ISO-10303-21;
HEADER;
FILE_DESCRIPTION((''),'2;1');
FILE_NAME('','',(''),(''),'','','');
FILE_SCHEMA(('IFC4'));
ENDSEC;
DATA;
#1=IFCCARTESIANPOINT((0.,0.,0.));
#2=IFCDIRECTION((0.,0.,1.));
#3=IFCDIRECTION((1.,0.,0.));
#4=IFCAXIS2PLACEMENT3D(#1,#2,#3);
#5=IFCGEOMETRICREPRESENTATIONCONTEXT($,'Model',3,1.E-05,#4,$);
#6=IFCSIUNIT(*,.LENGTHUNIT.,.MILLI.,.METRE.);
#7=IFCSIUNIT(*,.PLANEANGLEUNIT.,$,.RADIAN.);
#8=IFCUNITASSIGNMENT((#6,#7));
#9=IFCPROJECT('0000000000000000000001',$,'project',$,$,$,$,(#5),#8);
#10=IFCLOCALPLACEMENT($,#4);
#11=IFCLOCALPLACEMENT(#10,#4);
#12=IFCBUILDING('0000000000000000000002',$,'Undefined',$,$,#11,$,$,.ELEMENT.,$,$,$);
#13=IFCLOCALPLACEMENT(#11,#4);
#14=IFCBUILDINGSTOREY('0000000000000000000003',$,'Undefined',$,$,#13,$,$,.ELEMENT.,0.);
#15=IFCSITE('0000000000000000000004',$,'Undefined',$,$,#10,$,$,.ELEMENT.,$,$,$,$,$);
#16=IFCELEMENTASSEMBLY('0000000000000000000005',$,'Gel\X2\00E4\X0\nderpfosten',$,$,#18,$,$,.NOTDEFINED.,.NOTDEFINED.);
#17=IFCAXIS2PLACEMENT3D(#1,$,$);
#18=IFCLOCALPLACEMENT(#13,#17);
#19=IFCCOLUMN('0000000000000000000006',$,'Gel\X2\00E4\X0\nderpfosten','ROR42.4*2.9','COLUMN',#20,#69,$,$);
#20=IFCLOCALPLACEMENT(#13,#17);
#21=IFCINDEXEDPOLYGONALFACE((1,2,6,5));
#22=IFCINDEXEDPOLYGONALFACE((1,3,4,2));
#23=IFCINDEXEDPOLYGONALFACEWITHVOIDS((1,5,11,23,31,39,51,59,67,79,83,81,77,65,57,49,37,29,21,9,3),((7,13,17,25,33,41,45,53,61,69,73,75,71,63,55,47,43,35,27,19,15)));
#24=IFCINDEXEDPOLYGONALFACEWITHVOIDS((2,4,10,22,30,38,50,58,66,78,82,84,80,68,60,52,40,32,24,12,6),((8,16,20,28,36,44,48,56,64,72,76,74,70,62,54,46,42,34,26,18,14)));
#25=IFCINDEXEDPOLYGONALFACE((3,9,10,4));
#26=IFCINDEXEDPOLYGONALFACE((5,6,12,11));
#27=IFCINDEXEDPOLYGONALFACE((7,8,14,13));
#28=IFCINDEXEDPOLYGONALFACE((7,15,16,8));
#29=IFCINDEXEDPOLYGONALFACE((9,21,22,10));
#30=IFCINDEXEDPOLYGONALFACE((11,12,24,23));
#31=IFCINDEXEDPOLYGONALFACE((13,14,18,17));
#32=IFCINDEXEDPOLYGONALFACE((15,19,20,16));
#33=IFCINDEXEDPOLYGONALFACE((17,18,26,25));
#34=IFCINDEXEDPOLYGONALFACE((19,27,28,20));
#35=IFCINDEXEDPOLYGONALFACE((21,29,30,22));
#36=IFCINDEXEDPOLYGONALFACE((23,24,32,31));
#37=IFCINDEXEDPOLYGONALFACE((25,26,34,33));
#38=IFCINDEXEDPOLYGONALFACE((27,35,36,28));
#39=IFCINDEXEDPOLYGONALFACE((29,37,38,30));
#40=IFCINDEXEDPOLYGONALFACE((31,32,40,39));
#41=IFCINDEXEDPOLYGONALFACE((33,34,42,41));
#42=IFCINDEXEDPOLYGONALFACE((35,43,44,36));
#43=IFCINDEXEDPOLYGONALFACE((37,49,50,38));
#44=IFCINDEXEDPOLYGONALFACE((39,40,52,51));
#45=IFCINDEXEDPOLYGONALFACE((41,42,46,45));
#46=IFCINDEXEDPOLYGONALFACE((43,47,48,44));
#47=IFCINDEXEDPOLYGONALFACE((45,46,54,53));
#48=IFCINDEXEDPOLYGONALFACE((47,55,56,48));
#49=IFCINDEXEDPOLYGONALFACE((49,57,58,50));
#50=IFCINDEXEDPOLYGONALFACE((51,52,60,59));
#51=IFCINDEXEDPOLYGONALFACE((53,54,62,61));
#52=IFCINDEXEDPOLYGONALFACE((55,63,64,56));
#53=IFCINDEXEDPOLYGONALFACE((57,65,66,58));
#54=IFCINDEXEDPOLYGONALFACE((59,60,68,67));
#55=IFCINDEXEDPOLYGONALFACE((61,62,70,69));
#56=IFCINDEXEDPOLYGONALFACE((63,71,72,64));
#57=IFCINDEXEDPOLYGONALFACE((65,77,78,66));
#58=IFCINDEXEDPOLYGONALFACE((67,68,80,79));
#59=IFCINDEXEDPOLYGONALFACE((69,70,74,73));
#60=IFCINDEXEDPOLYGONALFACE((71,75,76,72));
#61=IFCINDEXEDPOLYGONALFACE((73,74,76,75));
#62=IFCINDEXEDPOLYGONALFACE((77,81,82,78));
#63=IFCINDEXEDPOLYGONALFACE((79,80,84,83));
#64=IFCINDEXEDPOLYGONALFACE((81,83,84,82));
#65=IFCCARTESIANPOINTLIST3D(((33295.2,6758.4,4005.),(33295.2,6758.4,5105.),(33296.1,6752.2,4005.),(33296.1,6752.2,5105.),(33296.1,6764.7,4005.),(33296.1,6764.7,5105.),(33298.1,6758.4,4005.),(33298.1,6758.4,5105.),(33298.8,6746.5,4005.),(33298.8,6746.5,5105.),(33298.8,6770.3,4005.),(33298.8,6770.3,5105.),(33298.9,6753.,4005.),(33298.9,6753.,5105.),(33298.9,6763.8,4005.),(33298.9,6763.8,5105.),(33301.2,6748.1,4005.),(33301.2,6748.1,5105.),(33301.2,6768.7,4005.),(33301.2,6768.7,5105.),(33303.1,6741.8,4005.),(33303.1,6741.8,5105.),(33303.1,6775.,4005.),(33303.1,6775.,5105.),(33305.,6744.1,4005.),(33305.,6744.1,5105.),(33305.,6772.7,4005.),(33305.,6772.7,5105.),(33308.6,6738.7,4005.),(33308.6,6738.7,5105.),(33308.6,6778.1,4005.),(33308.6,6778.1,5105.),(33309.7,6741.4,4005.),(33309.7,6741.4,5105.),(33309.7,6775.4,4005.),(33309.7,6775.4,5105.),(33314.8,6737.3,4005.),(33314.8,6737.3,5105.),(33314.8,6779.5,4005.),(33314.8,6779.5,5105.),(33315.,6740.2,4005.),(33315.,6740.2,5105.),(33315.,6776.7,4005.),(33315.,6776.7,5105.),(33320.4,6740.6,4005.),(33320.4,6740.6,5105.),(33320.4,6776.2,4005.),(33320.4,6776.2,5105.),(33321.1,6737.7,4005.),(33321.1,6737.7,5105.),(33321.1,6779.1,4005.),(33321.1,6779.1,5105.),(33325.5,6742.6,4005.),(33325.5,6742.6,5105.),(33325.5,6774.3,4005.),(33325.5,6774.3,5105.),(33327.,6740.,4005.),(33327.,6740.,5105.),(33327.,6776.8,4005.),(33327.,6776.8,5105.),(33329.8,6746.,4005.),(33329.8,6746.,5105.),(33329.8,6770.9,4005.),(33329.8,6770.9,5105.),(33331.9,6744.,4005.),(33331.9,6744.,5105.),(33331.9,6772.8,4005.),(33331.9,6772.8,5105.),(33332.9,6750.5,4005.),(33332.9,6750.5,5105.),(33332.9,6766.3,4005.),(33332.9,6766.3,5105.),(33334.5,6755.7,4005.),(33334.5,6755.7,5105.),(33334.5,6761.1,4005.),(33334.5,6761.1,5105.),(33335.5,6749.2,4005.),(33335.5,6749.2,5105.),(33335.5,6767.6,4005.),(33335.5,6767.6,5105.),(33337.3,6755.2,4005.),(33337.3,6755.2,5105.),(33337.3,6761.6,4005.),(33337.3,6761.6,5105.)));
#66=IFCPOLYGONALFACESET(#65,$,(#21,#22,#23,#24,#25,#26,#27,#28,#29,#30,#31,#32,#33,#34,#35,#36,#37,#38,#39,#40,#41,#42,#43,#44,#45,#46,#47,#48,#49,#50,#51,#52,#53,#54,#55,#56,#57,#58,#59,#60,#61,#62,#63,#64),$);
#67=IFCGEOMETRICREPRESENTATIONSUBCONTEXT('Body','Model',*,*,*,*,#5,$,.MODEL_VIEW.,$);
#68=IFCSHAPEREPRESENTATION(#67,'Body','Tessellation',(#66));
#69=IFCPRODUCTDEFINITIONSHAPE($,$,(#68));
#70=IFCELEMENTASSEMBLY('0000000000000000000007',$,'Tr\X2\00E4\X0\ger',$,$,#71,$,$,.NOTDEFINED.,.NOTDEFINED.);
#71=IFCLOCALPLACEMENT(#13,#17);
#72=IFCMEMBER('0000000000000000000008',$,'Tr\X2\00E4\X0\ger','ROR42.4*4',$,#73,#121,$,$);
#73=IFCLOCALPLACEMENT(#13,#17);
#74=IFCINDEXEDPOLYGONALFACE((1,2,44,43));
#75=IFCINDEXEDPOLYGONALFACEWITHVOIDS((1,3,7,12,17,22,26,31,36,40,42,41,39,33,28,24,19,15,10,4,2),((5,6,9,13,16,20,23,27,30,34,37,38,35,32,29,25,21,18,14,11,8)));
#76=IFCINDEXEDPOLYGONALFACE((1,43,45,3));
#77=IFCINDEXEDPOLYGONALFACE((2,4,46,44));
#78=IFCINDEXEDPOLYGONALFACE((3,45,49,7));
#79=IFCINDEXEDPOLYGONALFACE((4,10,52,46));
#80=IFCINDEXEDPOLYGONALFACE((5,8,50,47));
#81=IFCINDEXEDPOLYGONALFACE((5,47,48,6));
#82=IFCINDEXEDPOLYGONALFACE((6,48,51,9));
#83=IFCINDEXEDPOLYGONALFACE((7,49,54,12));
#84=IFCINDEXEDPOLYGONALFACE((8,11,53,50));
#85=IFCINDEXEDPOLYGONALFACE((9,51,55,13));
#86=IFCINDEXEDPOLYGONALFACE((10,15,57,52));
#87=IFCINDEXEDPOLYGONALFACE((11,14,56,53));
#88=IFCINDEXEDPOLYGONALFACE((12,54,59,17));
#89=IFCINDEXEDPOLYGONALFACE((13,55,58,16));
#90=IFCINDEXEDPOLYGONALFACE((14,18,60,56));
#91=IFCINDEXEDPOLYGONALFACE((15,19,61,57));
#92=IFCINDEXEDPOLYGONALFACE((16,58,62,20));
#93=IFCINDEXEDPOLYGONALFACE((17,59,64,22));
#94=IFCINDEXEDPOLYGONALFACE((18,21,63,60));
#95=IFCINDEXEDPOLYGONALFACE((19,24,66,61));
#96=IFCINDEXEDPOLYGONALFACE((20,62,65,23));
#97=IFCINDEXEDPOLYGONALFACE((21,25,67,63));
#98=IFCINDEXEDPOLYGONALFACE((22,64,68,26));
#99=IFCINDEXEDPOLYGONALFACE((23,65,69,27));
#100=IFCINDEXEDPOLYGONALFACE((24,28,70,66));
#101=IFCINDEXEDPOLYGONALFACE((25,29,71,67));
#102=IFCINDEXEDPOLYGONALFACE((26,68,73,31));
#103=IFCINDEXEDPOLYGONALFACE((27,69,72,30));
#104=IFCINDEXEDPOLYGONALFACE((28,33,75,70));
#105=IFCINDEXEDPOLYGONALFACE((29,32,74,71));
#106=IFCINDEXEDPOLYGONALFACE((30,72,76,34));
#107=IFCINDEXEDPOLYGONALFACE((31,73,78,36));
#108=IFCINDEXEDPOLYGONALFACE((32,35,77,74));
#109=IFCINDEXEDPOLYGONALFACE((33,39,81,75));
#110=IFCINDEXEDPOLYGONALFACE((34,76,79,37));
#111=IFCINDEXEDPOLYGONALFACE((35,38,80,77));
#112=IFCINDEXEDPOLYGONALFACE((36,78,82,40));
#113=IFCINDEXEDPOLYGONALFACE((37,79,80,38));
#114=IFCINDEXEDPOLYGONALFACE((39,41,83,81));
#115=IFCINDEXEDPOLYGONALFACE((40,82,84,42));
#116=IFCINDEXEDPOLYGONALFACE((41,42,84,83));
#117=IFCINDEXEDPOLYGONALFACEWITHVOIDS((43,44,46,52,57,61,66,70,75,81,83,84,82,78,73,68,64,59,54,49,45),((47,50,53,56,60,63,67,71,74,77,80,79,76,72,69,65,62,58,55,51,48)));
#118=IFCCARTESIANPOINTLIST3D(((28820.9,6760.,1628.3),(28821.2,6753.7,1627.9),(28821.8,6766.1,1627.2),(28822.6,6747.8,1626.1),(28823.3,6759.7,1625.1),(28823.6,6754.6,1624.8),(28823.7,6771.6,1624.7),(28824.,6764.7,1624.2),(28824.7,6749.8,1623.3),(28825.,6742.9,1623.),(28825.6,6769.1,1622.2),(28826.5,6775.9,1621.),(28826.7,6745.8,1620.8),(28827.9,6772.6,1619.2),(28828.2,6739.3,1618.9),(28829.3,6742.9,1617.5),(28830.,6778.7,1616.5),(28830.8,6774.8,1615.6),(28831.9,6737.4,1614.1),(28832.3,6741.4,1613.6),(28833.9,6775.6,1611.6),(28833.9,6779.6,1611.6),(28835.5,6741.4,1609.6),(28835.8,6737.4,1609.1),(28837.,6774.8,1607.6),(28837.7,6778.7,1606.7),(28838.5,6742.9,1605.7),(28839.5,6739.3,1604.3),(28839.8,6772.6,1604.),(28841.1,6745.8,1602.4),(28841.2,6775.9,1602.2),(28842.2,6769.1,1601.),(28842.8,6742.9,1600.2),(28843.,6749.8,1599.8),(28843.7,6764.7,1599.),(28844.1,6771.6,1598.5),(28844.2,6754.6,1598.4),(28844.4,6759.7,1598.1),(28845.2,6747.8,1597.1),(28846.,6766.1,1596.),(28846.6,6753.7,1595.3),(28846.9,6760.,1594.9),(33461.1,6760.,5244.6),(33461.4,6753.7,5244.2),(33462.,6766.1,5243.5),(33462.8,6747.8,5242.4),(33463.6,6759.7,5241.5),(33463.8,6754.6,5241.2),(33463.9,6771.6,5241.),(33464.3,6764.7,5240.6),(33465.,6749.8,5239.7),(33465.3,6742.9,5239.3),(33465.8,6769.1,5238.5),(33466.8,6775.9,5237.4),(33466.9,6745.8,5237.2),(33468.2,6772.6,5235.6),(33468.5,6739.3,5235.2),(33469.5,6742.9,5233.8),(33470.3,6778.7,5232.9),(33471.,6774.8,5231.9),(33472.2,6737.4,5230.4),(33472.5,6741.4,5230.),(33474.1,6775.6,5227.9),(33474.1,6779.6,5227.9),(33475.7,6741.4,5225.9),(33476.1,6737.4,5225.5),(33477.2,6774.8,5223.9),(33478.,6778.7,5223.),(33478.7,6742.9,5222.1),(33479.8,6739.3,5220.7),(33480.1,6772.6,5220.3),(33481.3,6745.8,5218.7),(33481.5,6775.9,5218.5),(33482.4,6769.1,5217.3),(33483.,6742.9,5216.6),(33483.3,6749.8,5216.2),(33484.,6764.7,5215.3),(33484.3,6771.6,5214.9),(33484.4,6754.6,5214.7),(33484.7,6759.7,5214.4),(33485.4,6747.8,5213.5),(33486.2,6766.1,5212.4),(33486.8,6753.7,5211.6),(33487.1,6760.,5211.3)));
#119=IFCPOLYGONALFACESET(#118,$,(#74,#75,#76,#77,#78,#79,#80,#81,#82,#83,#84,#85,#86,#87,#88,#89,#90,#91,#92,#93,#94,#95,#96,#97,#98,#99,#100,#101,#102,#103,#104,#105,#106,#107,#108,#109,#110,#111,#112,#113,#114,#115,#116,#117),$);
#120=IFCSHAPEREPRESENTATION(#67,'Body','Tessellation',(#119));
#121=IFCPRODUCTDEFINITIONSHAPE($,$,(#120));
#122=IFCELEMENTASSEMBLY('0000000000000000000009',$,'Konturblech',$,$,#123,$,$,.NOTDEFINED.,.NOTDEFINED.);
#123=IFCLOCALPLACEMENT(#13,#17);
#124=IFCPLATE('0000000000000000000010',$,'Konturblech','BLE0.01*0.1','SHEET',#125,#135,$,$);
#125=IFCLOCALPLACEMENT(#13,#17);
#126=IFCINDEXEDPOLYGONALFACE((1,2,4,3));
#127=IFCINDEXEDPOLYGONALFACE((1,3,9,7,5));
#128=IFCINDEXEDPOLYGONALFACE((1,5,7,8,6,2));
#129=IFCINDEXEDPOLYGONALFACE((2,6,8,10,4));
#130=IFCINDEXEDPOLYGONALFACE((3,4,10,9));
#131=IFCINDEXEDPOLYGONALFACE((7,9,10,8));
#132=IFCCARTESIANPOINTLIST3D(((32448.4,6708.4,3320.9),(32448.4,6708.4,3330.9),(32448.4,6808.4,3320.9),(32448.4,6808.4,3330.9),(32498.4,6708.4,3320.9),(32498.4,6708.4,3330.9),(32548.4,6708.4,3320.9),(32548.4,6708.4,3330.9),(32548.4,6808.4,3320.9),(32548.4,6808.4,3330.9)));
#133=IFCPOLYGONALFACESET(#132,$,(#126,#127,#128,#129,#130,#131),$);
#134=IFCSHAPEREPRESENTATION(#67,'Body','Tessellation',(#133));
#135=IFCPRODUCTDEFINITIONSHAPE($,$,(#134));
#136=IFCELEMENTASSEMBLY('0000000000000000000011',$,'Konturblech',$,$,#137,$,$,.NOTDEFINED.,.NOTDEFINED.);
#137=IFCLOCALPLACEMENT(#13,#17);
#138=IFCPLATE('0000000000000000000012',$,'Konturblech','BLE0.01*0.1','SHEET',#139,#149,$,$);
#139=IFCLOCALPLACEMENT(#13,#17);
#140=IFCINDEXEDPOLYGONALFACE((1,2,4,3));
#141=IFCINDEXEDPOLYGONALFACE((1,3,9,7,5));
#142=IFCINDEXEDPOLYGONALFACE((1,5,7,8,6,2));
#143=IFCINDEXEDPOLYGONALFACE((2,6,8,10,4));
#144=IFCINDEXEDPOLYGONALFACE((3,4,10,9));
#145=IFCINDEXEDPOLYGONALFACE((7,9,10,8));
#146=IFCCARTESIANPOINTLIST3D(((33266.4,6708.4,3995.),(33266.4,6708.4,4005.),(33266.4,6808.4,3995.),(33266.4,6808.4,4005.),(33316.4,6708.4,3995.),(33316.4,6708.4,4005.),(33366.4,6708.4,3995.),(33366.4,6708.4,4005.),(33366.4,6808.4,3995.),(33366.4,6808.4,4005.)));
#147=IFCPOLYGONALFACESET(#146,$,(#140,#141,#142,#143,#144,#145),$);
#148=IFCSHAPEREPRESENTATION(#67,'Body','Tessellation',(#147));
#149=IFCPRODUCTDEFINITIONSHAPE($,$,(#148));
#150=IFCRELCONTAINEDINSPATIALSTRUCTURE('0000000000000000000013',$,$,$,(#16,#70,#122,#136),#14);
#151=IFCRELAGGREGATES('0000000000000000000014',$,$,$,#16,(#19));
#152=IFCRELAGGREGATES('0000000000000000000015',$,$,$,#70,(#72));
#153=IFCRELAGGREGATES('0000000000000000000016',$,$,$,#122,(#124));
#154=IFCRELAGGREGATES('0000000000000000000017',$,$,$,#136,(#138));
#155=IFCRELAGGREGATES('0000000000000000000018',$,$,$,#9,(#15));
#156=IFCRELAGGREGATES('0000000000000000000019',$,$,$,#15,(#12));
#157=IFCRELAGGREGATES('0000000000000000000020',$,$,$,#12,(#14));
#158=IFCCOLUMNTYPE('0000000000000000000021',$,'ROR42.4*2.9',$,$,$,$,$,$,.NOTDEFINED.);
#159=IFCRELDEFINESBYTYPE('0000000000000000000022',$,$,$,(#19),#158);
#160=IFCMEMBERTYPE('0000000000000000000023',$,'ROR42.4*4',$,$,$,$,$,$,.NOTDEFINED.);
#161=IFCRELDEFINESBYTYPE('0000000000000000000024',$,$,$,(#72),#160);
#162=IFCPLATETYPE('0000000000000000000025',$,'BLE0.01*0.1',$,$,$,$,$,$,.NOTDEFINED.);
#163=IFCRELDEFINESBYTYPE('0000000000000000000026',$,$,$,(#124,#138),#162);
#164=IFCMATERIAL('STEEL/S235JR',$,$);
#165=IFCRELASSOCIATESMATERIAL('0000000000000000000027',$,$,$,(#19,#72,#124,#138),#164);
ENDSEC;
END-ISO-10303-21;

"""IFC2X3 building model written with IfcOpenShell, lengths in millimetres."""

from ifc_helpers import new_model, si_unit, frame, origin_with_axes, origin_2d_with_axis, place, context, subcontext, project, spatial, polyline, hollow_circle, outline, extrude, material, type_object, element, aggregate, save


model = new_model("IFC2X3")

# Units and contexts
model_context = context("Model", 3, precision=1e-05, world=origin_with_axes())
body_context = subcontext(model_context, "Body", "Model", "MODEL_VIEW")
ifc_project = project(units=[si_unit("LENGTHUNIT", "METRE", prefix="MILLI"), si_unit("PLANEANGLEUNIT", "RADIAN")], contexts=[model_context])

# Site, building, storey
site_placement = place(None, origin_with_axes())
site = spatial("IfcSite", under=ifc_project, at=site_placement, Name="Undefined", CompositionType="ELEMENT")
building_placement = place(site_placement, origin_with_axes())
building = spatial("IfcBuilding", under=site, at=building_placement, Name="Undefined", CompositionType="ELEMENT")
storey_placement = place(building_placement, origin_with_axes())
storey = spatial("IfcBuildingStorey", under=building, at=storey_placement, Name="Undefined", CompositionType="ELEMENT", Elevation=0.0)

# Element assembly, column
assembly_1_placement = place(storey_placement, origin_with_axes())
assembly_1 = element("IfcElementAssembly", 1, at=assembly_1_placement, inside=storey, Name="Geländerpfosten", AssemblyPlace="NOTDEFINED", PredefinedType="NOTDEFINED")
ifc_material_1 = material(Name="STEEL/S235JR")
column_type = type_object("IfcColumnType", Name="ROR42.4*2.9", PredefinedType="NOTDEFINED")
column_placement = place(assembly_1_placement, frame((33316.4, 6758.4, 4005.0), z_axis=(0.0, 0.0, 1.0), x_axis=(0.0, 1.0, 0.0)))
column = element("IfcColumn", 2, at=column_placement, type_object=column_type, material=ifc_material_1, Name="Geländerpfosten", Description="ROR42.4*2.9", ObjectType="COLUMN", context=body_context, shape_type="SweptSolid", body=[
    extrude(hollow_circle(Radius=21.2, WallThickness=2.9, at=origin_2d_with_axis()), frame((0.0, 0.0, 1100.0), z_axis=(0.0, 0.0, -1.0), x_axis=(0.0, 1.0, 0.0)), (0.0, 0.0, 1.0), 1100.0),
])
aggregate(assembly_1, [column])

# Element assembly, member
assembly_2_placement = place(storey_placement, origin_with_axes())
assembly_2 = element("IfcElementAssembly", 3, at=assembly_2_placement, inside=storey, Name="Träger", AssemblyPlace="NOTDEFINED", PredefinedType="NOTDEFINED")
member_type = type_object("IfcMemberType", Name="ROR42.4*4", PredefinedType="NOTDEFINED")
member_placement = place(assembly_2_placement, frame((33474.1, 6758.4, 5227.9), z_axis=(-0.614711, 0.0, 0.788752), x_axis=(-0.788752, 0.0, -0.614711)))
member = element("IfcMember", 4, at=member_placement, type_object=member_type, material=ifc_material_1, Name="Träger", Description="ROR42.4*4", context=body_context, shape_type="SweptSolid", body=[
    extrude(hollow_circle(Radius=21.2, WallThickness=4.0, at=origin_2d_with_axis()), frame((5883.0, 0.0, 0.0), z_axis=(-1.0, 0.0, 0.0), x_axis=(0.0, -1.0, 0.0)), (0.0, 0.0, 1.0), 5883.0),
])
aggregate(assembly_2, [member])

# Element assemblies, plates
assembly_3_placement = place(storey_placement, origin_with_axes())
assembly_3 = element("IfcElementAssembly", 5, at=assembly_3_placement, inside=storey, Name="Konturblech", AssemblyPlace="NOTDEFINED", PredefinedType="NOTDEFINED")
plate_type = type_object("IfcPlateType", Name="BLE0.01*0.1", PredefinedType="NOTDEFINED")
plate_1_placement = place(assembly_3_placement, frame((32498.4, 6708.4, 3325.9), z_axis=(0.0, 0.0, 1.0), x_axis=(1.0, 0.0, 0.0)))
plate_1 = element("IfcPlate", 6, at=plate_1_placement, type_object=plate_type, material=ifc_material_1, Name="Konturblech", Description="BLE0.01*0.1", ObjectType="SHEET", context=body_context, shape_type="SweptSolid", body=[
    extrude(outline(polyline([(0.0, 0.0), (50.0, 0.0), (50.0, 100.0), (-50.0, 100.0), (-50.0, 0.0), (0.0, 0.0)])), frame((0.0, 0.0, -5.0), z_axis=(0.0, 0.0, 1.0), x_axis=(1.0, 0.0, 0.0)), (0.0, 0.0, 1.0), 10.0),
])
aggregate(assembly_3, [plate_1])
assembly_4_placement = place(storey_placement, origin_with_axes())
assembly_4 = element("IfcElementAssembly", 7, at=assembly_4_placement, inside=storey, Name="Konturblech", AssemblyPlace="NOTDEFINED", PredefinedType="NOTDEFINED")
plate_2_placement = place(assembly_4_placement, frame((33316.4, 6708.4, 4000.0), z_axis=(0.0, 0.0, 1.0), x_axis=(1.0, 0.0, 0.0)))
plate_2 = element("IfcPlate", 8, at=plate_2_placement, type_object=plate_type, material=ifc_material_1, Name="Konturblech", Description="BLE0.01*0.1", ObjectType="SHEET", context=body_context, shape_type="SweptSolid", body=[
    extrude(outline(polyline([(0.0, 0.0), (50.0, 0.0), (50.0, 100.0), (-50.0, 100.0), (-50.0, 0.0), (0.0, 0.0)])), frame((0.0, 0.0, -5.0), z_axis=(0.0, 0.0, 1.0), x_axis=(1.0, 0.0, 0.0)), (0.0, 0.0, 1.0), 10.0),
])
aggregate(assembly_4, [plate_2])

save(model, "model.ifc")
